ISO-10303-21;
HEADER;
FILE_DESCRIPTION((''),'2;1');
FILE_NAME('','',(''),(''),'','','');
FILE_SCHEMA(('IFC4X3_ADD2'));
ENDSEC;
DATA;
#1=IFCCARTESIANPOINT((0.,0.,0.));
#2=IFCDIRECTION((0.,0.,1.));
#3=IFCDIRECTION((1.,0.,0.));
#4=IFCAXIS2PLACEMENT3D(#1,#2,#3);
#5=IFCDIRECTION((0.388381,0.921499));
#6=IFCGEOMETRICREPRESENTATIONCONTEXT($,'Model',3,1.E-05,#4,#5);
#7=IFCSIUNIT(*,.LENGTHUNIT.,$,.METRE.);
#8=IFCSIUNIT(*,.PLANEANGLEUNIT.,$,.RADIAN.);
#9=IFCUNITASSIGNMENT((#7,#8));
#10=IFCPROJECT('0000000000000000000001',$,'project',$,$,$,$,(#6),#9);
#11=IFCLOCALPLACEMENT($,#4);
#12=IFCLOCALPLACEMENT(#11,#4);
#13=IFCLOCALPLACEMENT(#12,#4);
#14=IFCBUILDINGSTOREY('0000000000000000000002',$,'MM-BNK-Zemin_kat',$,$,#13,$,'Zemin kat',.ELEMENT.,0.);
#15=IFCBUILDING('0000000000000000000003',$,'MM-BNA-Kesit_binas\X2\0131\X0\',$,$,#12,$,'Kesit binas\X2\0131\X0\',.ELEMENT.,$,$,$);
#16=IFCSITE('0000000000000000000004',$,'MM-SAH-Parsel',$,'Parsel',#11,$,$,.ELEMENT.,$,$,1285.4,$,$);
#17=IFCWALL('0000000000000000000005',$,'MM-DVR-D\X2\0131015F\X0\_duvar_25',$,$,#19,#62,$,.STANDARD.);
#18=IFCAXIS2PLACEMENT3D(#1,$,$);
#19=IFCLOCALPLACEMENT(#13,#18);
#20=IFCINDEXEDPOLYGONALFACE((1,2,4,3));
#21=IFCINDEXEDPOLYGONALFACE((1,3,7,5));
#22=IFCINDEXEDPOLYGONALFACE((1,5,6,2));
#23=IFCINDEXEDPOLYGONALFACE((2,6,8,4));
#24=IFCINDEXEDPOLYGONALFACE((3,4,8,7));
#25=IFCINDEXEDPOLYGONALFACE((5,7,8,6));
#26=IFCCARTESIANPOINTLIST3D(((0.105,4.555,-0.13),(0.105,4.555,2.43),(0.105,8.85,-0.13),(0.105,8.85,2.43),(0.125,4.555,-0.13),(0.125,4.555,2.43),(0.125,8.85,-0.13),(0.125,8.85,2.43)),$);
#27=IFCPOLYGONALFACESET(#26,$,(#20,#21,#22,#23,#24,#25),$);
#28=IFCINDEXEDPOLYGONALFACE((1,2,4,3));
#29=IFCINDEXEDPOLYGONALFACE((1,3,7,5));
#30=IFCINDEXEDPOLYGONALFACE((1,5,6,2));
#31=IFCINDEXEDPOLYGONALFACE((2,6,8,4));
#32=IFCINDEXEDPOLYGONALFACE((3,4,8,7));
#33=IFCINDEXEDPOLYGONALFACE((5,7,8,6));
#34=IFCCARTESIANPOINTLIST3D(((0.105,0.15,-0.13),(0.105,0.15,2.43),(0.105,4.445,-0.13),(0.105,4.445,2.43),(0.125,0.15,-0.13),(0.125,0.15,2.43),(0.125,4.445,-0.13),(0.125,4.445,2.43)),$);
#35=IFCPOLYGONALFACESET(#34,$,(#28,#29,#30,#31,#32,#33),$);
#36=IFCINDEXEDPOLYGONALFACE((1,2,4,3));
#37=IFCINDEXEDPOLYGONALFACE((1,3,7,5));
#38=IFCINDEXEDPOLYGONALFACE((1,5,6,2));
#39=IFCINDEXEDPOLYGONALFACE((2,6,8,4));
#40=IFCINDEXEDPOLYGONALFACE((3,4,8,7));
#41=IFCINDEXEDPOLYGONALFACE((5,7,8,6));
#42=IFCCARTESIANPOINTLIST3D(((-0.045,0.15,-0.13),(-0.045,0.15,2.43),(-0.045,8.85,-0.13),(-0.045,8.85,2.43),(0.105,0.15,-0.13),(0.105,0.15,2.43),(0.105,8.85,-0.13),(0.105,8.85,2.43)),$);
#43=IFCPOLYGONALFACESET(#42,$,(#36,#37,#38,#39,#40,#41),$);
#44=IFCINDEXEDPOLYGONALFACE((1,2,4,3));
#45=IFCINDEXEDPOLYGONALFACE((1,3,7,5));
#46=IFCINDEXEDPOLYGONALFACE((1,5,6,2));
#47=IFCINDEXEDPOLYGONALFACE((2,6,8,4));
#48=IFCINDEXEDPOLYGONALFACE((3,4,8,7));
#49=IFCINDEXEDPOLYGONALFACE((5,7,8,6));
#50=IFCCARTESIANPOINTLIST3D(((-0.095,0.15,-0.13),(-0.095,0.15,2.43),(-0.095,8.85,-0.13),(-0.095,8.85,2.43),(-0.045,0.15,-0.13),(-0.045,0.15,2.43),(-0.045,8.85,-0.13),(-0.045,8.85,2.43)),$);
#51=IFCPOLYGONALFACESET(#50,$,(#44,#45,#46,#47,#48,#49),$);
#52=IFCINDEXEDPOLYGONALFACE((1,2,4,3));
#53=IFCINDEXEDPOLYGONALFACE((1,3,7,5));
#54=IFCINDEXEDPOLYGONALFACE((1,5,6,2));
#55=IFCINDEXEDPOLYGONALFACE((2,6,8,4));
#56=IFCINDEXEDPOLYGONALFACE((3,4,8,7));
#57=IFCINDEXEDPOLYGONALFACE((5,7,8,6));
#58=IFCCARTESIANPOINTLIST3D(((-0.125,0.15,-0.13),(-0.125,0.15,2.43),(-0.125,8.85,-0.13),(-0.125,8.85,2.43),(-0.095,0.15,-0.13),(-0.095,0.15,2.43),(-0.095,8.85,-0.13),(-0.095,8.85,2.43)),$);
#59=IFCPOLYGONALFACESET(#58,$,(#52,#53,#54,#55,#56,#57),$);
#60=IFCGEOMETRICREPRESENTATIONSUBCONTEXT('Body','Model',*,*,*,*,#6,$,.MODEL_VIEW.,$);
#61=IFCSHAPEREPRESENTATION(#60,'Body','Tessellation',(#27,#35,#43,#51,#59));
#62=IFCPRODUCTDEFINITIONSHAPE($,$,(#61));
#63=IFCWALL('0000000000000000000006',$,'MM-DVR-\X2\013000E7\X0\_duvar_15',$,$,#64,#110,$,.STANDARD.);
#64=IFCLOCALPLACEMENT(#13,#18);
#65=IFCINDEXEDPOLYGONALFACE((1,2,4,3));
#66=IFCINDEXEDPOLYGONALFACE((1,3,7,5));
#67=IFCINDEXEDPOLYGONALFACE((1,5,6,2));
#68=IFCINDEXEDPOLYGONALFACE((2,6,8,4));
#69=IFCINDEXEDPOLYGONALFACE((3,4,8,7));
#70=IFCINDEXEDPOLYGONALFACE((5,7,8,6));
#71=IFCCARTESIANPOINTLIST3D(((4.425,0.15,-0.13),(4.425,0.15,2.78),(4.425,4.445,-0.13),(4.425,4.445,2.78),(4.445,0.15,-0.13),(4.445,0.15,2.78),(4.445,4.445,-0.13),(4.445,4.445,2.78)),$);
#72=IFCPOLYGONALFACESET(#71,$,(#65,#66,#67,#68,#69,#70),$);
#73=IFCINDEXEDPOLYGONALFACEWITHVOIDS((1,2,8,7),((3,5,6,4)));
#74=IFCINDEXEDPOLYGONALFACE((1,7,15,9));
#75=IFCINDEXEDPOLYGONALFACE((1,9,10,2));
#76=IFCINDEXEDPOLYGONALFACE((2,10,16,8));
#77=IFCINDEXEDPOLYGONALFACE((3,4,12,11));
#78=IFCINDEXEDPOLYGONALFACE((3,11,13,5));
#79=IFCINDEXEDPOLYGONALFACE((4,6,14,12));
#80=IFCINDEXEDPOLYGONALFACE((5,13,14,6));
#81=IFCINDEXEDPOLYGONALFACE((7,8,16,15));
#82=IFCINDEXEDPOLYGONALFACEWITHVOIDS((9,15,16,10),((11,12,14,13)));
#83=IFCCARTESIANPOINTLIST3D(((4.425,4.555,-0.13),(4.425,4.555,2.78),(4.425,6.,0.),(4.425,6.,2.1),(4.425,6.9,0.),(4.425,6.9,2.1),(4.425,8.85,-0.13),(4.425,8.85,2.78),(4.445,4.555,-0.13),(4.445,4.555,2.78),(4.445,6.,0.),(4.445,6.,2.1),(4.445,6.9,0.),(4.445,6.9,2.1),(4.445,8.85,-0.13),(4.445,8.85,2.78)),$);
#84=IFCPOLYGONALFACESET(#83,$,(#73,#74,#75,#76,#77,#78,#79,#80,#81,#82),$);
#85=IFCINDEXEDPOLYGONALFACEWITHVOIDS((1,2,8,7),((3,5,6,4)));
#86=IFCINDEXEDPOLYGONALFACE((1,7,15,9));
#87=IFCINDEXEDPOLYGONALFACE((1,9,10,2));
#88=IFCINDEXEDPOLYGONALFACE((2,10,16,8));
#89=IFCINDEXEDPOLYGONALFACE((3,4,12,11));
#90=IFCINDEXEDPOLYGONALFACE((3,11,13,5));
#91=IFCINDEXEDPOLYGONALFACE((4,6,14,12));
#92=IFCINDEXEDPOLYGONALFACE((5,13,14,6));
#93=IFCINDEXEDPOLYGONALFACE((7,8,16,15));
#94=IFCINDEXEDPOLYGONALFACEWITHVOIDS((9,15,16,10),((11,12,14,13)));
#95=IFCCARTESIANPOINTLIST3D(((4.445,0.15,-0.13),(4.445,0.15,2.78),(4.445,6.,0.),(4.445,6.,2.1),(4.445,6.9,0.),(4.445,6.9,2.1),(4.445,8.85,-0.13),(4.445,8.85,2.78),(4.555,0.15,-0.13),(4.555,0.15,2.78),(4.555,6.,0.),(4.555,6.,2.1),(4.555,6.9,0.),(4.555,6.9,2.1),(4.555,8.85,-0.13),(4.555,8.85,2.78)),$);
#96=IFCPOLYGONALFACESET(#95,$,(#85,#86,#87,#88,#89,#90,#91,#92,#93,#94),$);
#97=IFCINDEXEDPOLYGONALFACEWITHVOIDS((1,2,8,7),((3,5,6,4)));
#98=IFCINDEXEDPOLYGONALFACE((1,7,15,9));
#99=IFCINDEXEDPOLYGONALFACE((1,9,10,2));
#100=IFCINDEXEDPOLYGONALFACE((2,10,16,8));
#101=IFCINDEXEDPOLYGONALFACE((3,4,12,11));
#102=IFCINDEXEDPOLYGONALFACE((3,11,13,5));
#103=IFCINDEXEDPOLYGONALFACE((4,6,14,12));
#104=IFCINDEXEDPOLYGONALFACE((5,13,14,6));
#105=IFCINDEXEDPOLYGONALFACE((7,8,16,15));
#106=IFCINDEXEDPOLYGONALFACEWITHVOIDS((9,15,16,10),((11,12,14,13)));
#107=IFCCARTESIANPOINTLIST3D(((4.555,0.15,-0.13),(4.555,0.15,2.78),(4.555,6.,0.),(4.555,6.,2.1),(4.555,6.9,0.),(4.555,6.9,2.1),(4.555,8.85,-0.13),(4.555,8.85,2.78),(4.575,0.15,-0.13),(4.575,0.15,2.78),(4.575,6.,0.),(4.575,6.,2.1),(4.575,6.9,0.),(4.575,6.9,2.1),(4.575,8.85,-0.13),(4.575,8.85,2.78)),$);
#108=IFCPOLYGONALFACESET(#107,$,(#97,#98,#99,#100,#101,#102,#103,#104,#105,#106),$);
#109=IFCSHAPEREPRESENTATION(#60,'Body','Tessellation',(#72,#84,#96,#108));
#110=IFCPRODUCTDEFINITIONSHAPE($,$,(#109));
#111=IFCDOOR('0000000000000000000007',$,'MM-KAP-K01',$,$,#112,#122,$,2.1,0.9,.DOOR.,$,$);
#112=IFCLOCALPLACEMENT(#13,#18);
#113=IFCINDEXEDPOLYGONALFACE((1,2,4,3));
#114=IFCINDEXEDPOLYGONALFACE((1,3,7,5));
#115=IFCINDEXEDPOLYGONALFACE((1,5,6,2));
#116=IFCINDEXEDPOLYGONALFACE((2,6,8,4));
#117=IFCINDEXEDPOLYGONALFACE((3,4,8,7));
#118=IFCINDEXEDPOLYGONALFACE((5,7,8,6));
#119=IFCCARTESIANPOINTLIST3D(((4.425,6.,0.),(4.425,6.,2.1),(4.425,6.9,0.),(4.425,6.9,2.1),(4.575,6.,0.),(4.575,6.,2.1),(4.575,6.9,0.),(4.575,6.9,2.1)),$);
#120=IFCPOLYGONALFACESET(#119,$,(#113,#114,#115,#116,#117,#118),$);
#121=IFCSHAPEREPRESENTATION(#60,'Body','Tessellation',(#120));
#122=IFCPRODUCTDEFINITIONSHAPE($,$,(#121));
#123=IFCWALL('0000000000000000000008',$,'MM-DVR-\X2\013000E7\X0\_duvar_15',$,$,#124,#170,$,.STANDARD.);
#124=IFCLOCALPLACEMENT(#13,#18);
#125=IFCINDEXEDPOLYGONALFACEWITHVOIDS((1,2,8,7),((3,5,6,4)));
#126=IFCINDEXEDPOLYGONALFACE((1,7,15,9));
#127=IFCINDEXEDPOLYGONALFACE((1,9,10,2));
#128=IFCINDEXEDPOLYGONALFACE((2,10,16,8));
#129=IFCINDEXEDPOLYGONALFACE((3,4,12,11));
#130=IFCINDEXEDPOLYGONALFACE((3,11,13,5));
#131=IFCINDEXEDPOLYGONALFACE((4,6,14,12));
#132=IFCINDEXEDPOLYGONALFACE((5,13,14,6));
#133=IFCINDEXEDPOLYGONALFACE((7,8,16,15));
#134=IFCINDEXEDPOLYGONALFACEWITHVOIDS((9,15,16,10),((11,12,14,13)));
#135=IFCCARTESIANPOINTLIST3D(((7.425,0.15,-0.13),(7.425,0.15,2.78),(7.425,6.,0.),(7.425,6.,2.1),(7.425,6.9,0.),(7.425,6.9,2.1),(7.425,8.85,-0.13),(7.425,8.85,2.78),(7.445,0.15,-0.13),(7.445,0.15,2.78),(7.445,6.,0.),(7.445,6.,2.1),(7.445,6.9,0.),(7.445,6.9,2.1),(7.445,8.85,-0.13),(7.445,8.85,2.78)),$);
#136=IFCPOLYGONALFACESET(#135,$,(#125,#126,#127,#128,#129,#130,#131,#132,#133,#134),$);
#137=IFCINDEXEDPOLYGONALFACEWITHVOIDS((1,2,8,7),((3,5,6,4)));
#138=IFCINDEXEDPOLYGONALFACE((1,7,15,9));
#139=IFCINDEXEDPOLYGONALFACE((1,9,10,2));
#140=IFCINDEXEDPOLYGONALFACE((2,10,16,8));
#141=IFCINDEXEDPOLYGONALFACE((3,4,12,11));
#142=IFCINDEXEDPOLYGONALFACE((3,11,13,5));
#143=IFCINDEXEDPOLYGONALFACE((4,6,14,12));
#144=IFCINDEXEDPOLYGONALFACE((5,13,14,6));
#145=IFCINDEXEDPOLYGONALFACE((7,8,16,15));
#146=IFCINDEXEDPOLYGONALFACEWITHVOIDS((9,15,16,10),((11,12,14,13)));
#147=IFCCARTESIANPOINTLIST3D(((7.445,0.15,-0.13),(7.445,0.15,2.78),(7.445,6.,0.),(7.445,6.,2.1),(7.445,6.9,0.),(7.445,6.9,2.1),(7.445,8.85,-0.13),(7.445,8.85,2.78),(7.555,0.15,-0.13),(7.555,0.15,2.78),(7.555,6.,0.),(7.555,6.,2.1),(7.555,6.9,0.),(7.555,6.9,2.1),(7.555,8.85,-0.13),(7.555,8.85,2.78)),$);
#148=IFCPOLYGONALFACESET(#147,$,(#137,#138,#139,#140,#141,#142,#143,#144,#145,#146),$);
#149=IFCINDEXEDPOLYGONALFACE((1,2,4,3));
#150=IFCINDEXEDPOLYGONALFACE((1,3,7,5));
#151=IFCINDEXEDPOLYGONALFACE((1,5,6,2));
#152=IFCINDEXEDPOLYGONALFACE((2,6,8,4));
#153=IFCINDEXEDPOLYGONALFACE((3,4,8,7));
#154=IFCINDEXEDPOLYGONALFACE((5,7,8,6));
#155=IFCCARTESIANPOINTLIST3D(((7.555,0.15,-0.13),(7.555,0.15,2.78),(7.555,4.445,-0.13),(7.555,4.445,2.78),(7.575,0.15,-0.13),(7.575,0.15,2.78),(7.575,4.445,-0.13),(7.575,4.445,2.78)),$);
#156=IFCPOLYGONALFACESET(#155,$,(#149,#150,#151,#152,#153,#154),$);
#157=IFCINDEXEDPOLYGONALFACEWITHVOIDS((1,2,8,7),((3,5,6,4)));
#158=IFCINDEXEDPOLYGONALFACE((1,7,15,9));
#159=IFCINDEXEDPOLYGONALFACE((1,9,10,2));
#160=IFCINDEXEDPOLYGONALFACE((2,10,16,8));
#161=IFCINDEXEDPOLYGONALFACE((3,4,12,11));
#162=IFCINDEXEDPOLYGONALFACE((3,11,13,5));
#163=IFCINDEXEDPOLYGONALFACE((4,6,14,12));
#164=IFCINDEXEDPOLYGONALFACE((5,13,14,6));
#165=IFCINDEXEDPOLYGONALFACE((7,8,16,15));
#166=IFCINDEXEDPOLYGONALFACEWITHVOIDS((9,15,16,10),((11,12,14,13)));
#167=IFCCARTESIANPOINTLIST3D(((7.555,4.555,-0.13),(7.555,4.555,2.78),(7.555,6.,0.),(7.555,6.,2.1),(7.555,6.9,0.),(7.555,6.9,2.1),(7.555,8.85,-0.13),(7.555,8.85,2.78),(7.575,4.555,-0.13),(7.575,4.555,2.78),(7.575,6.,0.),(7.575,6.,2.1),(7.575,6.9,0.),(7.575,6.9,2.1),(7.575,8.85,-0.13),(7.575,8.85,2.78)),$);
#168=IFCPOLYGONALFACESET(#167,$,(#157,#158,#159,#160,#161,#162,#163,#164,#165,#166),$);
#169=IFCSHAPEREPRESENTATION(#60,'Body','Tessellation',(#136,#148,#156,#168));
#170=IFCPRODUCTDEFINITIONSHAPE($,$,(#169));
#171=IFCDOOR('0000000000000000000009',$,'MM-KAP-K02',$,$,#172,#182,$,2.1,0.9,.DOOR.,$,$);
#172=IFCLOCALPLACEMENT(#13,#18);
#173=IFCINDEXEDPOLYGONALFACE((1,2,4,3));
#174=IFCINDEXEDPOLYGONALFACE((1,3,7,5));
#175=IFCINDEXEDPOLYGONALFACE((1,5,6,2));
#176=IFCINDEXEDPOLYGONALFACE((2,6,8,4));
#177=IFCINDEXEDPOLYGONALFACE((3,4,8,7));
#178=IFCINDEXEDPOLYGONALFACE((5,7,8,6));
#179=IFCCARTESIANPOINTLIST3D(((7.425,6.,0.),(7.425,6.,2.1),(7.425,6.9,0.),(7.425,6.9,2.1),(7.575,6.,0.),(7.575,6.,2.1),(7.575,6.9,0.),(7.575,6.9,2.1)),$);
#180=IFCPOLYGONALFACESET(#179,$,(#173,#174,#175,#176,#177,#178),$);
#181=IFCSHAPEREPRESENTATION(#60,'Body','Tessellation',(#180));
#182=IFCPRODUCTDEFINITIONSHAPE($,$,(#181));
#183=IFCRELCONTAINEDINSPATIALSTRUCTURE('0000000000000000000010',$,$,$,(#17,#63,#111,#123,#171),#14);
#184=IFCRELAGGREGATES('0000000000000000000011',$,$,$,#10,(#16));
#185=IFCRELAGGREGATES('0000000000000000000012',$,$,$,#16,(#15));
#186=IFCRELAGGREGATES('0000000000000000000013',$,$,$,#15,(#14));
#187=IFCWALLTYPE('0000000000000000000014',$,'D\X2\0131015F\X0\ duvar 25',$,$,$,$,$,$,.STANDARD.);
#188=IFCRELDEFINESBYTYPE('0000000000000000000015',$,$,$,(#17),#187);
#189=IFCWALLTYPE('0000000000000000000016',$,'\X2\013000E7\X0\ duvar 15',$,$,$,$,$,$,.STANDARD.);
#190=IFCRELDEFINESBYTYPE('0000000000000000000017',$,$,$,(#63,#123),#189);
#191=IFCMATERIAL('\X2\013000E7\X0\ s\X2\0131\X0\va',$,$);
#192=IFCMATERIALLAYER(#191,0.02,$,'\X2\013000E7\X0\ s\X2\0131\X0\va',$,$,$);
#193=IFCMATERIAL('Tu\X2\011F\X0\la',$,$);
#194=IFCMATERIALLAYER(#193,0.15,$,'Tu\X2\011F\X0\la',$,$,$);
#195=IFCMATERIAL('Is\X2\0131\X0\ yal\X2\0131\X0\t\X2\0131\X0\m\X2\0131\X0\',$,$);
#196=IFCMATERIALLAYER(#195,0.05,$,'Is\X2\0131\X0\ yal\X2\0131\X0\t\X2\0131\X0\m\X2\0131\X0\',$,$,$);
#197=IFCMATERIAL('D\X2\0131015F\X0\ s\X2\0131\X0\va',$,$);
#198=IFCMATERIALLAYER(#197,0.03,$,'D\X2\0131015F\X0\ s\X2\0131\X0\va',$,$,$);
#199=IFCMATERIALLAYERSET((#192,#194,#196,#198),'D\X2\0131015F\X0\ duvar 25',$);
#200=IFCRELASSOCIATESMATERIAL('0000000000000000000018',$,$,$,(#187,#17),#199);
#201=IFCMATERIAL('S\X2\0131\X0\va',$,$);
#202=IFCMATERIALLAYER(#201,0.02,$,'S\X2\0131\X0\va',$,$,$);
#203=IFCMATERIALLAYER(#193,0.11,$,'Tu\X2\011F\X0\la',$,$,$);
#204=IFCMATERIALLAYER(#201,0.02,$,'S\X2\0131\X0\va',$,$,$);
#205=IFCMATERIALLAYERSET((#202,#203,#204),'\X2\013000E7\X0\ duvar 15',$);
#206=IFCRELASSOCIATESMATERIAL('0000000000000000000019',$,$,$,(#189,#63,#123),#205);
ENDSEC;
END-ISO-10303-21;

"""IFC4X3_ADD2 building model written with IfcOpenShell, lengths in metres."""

from ifc_helpers import new_model, si_unit, direction, frame, origin, origin_with_axes, place, context, subcontext, project, spatial, polyline, outline, extrude, material, layer, layer_set, type_object, element, fill, save


model = new_model("IFC4X3_ADD2")

# Units and contexts
model_context = context("Model", 3, precision=1e-05, world=origin_with_axes(), true_north=direction((0.388381, 0.921499)))
body_context = subcontext(model_context, "Body", "Model", "MODEL_VIEW")
ifc_project = project(units=[si_unit("LENGTHUNIT", "METRE"), si_unit("PLANEANGLEUNIT", "RADIAN")], contexts=[model_context])

# Site, building, storey
site_placement = place(None, origin_with_axes())
site = spatial("IfcSite", under=ifc_project, at=site_placement, Name="MM-SAH-Parsel", ObjectType="Parsel", CompositionType="ELEMENT", RefElevation=1285.4)
building_placement = place(site_placement, origin_with_axes())
building = spatial("IfcBuilding", under=site, at=building_placement, Name="MM-BNA-Kesit_binası", LongName="Kesit binası", CompositionType="ELEMENT")
storey_placement = place(building_placement, origin_with_axes())
storey = spatial("IfcBuildingStorey", under=building, at=storey_placement, Name="MM-BNK-Zemin_kat", LongName="Zemin kat", CompositionType="ELEMENT", Elevation=0.0)

# Shared definitions
ifc_material_1 = material(Name="İç sıva")
ifc_layer_1 = layer(ifc_material_1, 0.02, Name="İç sıva")
ifc_material_2 = material(Name="Tuğla")
ifc_layer_2 = layer(ifc_material_2, 0.15, Name="Tuğla")
ifc_material_3 = material(Name="Isı yalıtımı")
ifc_layer_3 = layer(ifc_material_3, 0.05, Name="Isı yalıtımı")
ifc_material_4 = material(Name="Dış sıva")
ifc_layer_4 = layer(ifc_material_4, 0.03, Name="Dış sıva")
ifc_layer_set_1 = layer_set([ifc_layer_1, ifc_layer_2, ifc_layer_3, ifc_layer_4], Name="Dış duvar 25")
wall_type_1 = type_object("IfcWallType", Name="Dış duvar 25", PredefinedType="STANDARD", material=ifc_layer_set_1)

# Wall
wall_1_placement = place(storey_placement, origin_with_axes())
element("IfcWall", 1, at=wall_1_placement, inside=storey, type_object=wall_type_1, material=ifc_layer_set_1, Name="MM-DVR-Dış_duvar_25", PredefinedType="STANDARD", context=body_context, shape_type="SweptSolid", body=[
    extrude(outline(polyline([(0.105, 8.85), (0.105, 4.555), (0.125, 4.555), (0.125, 8.85), (0.105, 8.85)])), frame((0.0, 0.0, -0.13)), (0.0, 0.0, 1.0), 2.56),
    extrude(outline(polyline([(0.105, 4.445), (0.105, 0.15), (0.125, 0.15), (0.125, 4.445), (0.105, 4.445)])), frame((0.0, 0.0, -0.13)), (0.0, 0.0, 1.0), 2.56),
    extrude(outline(polyline([(-0.045, 8.85), (-0.045, 0.15), (0.105, 0.15), (0.105, 8.85), (-0.045, 8.85)])), frame((0.0, 0.0, -0.13)), (0.0, 0.0, 1.0), 2.56),
    extrude(outline(polyline([(-0.095, 8.85), (-0.095, 0.15), (-0.045, 0.15), (-0.045, 8.85), (-0.095, 8.85)])), frame((0.0, 0.0, -0.13)), (0.0, 0.0, 1.0), 2.56),
    extrude(outline(polyline([(-0.125, 8.85), (-0.125, 0.15), (-0.095, 0.15), (-0.095, 8.85), (-0.125, 8.85)])), frame((0.0, 0.0, -0.13)), (0.0, 0.0, 1.0), 2.56),
])

# Walls, openings, doors
ifc_material_5 = material(Name="Sıva")
ifc_layer_5 = layer(ifc_material_5, 0.02, Name="Sıva")
ifc_layer_6 = layer(ifc_material_2, 0.11, Name="Tuğla")
ifc_layer_7 = layer(ifc_material_5, 0.02, Name="Sıva")
ifc_layer_set_2 = layer_set([ifc_layer_5, ifc_layer_6, ifc_layer_7], Name="İç duvar 15")
wall_type_2 = type_object("IfcWallType", Name="İç duvar 15", PredefinedType="STANDARD", material=ifc_layer_set_2)
wall_2_placement = place(storey_placement, origin_with_axes())
wall_2 = element("IfcWall", 2, at=wall_2_placement, inside=storey, type_object=wall_type_2, material=ifc_layer_set_2, Name="MM-DVR-İç_duvar_15", PredefinedType="STANDARD", context=body_context, shape_type="SweptSolid", body=[
    extrude(outline(polyline([(4.445, 0.15), (4.445, 4.445), (4.425, 4.445), (4.425, 0.15), (4.445, 0.15)])), frame((0.0, 0.0, -0.13)), (0.0, 0.0, 1.0), 2.91),
    extrude(outline(polyline([(4.445, 4.555), (4.445, 8.85), (4.425, 8.85), (4.425, 4.555), (4.445, 4.555)])), frame((0.0, 0.0, -0.13)), (0.0, 0.0, 1.0), 2.91),
    extrude(outline(polyline([(4.555, 0.15), (4.555, 8.85), (4.445, 8.85), (4.445, 0.15), (4.555, 0.15)])), frame((0.0, 0.0, -0.13)), (0.0, 0.0, 1.0), 2.91),
    extrude(outline(polyline([(4.575, 0.15), (4.575, 8.85), (4.555, 8.85), (4.555, 0.15), (4.575, 0.15)])), frame((0.0, 0.0, -0.13)), (0.0, 0.0, 1.0), 2.91),
])
opening_1_placement = place(storey_placement, origin_with_axes())
opening_1 = element("IfcOpeningElement", 3, at=opening_1_placement, cuts=wall_2, PredefinedType="OPENING", context=body_context, shape_type="SweptSolid", body=[
    extrude(outline(polyline([(4.425, 6.0), (4.425, 6.9), (4.575, 6.9), (4.575, 6.0), (4.425, 6.0)])), origin(), (0.0, 0.0, 1.0), 2.1),
])
door_1_placement = place(storey_placement, origin_with_axes())
door_1 = element("IfcDoor", 4, at=door_1_placement, inside=storey, Name="MM-KAP-K01", OverallHeight=2.1, OverallWidth=0.9, PredefinedType="DOOR", context=body_context, shape_type="SweptSolid", body=[
    extrude(outline(polyline([(4.425, 6.0), (4.425, 6.9), (4.575, 6.9), (4.575, 6.0), (4.425, 6.0)])), origin(), (0.0, 0.0, 1.0), 2.1),
])
fill(opening_1, door_1)
wall_3_placement = place(storey_placement, origin_with_axes())
wall_3 = element("IfcWall", 5, at=wall_3_placement, inside=storey, type_object=wall_type_2, material=ifc_layer_set_2, Name="MM-DVR-İç_duvar_15", PredefinedType="STANDARD", context=body_context, shape_type="SweptSolid", body=[
    extrude(outline(polyline([(7.445, 0.15), (7.445, 8.85), (7.425, 8.85), (7.425, 0.15), (7.445, 0.15)])), frame((0.0, 0.0, -0.13)), (0.0, 0.0, 1.0), 2.91),
    extrude(outline(polyline([(7.555, 0.15), (7.555, 8.85), (7.445, 8.85), (7.445, 0.15), (7.555, 0.15)])), frame((0.0, 0.0, -0.13)), (0.0, 0.0, 1.0), 2.91),
    extrude(outline(polyline([(7.575, 0.15), (7.575, 4.445), (7.555, 4.445), (7.555, 0.15), (7.575, 0.15)])), frame((0.0, 0.0, -0.13)), (0.0, 0.0, 1.0), 2.91),
    extrude(outline(polyline([(7.575, 4.555), (7.575, 8.85), (7.555, 8.85), (7.555, 4.555), (7.575, 4.555)])), frame((0.0, 0.0, -0.13)), (0.0, 0.0, 1.0), 2.91),
])
opening_2_placement = place(storey_placement, origin_with_axes())
opening_2 = element("IfcOpeningElement", 6, at=opening_2_placement, cuts=wall_3, PredefinedType="OPENING", context=body_context, shape_type="SweptSolid", body=[
    extrude(outline(polyline([(7.425, 6.0), (7.425, 6.9), (7.575, 6.9), (7.575, 6.0), (7.425, 6.0)])), origin(), (0.0, 0.0, 1.0), 2.1),
])
door_2_placement = place(storey_placement, origin_with_axes())
door_2 = element("IfcDoor", 7, at=door_2_placement, inside=storey, Name="MM-KAP-K02", OverallHeight=2.1, OverallWidth=0.9, PredefinedType="DOOR", context=body_context, shape_type="SweptSolid", body=[
    extrude(outline(polyline([(7.425, 6.0), (7.425, 6.9), (7.575, 6.9), (7.575, 6.0), (7.425, 6.0)])), origin(), (0.0, 0.0, 1.0), 2.1),
])
fill(opening_2, door_2)

save(model, "model.ifc")
